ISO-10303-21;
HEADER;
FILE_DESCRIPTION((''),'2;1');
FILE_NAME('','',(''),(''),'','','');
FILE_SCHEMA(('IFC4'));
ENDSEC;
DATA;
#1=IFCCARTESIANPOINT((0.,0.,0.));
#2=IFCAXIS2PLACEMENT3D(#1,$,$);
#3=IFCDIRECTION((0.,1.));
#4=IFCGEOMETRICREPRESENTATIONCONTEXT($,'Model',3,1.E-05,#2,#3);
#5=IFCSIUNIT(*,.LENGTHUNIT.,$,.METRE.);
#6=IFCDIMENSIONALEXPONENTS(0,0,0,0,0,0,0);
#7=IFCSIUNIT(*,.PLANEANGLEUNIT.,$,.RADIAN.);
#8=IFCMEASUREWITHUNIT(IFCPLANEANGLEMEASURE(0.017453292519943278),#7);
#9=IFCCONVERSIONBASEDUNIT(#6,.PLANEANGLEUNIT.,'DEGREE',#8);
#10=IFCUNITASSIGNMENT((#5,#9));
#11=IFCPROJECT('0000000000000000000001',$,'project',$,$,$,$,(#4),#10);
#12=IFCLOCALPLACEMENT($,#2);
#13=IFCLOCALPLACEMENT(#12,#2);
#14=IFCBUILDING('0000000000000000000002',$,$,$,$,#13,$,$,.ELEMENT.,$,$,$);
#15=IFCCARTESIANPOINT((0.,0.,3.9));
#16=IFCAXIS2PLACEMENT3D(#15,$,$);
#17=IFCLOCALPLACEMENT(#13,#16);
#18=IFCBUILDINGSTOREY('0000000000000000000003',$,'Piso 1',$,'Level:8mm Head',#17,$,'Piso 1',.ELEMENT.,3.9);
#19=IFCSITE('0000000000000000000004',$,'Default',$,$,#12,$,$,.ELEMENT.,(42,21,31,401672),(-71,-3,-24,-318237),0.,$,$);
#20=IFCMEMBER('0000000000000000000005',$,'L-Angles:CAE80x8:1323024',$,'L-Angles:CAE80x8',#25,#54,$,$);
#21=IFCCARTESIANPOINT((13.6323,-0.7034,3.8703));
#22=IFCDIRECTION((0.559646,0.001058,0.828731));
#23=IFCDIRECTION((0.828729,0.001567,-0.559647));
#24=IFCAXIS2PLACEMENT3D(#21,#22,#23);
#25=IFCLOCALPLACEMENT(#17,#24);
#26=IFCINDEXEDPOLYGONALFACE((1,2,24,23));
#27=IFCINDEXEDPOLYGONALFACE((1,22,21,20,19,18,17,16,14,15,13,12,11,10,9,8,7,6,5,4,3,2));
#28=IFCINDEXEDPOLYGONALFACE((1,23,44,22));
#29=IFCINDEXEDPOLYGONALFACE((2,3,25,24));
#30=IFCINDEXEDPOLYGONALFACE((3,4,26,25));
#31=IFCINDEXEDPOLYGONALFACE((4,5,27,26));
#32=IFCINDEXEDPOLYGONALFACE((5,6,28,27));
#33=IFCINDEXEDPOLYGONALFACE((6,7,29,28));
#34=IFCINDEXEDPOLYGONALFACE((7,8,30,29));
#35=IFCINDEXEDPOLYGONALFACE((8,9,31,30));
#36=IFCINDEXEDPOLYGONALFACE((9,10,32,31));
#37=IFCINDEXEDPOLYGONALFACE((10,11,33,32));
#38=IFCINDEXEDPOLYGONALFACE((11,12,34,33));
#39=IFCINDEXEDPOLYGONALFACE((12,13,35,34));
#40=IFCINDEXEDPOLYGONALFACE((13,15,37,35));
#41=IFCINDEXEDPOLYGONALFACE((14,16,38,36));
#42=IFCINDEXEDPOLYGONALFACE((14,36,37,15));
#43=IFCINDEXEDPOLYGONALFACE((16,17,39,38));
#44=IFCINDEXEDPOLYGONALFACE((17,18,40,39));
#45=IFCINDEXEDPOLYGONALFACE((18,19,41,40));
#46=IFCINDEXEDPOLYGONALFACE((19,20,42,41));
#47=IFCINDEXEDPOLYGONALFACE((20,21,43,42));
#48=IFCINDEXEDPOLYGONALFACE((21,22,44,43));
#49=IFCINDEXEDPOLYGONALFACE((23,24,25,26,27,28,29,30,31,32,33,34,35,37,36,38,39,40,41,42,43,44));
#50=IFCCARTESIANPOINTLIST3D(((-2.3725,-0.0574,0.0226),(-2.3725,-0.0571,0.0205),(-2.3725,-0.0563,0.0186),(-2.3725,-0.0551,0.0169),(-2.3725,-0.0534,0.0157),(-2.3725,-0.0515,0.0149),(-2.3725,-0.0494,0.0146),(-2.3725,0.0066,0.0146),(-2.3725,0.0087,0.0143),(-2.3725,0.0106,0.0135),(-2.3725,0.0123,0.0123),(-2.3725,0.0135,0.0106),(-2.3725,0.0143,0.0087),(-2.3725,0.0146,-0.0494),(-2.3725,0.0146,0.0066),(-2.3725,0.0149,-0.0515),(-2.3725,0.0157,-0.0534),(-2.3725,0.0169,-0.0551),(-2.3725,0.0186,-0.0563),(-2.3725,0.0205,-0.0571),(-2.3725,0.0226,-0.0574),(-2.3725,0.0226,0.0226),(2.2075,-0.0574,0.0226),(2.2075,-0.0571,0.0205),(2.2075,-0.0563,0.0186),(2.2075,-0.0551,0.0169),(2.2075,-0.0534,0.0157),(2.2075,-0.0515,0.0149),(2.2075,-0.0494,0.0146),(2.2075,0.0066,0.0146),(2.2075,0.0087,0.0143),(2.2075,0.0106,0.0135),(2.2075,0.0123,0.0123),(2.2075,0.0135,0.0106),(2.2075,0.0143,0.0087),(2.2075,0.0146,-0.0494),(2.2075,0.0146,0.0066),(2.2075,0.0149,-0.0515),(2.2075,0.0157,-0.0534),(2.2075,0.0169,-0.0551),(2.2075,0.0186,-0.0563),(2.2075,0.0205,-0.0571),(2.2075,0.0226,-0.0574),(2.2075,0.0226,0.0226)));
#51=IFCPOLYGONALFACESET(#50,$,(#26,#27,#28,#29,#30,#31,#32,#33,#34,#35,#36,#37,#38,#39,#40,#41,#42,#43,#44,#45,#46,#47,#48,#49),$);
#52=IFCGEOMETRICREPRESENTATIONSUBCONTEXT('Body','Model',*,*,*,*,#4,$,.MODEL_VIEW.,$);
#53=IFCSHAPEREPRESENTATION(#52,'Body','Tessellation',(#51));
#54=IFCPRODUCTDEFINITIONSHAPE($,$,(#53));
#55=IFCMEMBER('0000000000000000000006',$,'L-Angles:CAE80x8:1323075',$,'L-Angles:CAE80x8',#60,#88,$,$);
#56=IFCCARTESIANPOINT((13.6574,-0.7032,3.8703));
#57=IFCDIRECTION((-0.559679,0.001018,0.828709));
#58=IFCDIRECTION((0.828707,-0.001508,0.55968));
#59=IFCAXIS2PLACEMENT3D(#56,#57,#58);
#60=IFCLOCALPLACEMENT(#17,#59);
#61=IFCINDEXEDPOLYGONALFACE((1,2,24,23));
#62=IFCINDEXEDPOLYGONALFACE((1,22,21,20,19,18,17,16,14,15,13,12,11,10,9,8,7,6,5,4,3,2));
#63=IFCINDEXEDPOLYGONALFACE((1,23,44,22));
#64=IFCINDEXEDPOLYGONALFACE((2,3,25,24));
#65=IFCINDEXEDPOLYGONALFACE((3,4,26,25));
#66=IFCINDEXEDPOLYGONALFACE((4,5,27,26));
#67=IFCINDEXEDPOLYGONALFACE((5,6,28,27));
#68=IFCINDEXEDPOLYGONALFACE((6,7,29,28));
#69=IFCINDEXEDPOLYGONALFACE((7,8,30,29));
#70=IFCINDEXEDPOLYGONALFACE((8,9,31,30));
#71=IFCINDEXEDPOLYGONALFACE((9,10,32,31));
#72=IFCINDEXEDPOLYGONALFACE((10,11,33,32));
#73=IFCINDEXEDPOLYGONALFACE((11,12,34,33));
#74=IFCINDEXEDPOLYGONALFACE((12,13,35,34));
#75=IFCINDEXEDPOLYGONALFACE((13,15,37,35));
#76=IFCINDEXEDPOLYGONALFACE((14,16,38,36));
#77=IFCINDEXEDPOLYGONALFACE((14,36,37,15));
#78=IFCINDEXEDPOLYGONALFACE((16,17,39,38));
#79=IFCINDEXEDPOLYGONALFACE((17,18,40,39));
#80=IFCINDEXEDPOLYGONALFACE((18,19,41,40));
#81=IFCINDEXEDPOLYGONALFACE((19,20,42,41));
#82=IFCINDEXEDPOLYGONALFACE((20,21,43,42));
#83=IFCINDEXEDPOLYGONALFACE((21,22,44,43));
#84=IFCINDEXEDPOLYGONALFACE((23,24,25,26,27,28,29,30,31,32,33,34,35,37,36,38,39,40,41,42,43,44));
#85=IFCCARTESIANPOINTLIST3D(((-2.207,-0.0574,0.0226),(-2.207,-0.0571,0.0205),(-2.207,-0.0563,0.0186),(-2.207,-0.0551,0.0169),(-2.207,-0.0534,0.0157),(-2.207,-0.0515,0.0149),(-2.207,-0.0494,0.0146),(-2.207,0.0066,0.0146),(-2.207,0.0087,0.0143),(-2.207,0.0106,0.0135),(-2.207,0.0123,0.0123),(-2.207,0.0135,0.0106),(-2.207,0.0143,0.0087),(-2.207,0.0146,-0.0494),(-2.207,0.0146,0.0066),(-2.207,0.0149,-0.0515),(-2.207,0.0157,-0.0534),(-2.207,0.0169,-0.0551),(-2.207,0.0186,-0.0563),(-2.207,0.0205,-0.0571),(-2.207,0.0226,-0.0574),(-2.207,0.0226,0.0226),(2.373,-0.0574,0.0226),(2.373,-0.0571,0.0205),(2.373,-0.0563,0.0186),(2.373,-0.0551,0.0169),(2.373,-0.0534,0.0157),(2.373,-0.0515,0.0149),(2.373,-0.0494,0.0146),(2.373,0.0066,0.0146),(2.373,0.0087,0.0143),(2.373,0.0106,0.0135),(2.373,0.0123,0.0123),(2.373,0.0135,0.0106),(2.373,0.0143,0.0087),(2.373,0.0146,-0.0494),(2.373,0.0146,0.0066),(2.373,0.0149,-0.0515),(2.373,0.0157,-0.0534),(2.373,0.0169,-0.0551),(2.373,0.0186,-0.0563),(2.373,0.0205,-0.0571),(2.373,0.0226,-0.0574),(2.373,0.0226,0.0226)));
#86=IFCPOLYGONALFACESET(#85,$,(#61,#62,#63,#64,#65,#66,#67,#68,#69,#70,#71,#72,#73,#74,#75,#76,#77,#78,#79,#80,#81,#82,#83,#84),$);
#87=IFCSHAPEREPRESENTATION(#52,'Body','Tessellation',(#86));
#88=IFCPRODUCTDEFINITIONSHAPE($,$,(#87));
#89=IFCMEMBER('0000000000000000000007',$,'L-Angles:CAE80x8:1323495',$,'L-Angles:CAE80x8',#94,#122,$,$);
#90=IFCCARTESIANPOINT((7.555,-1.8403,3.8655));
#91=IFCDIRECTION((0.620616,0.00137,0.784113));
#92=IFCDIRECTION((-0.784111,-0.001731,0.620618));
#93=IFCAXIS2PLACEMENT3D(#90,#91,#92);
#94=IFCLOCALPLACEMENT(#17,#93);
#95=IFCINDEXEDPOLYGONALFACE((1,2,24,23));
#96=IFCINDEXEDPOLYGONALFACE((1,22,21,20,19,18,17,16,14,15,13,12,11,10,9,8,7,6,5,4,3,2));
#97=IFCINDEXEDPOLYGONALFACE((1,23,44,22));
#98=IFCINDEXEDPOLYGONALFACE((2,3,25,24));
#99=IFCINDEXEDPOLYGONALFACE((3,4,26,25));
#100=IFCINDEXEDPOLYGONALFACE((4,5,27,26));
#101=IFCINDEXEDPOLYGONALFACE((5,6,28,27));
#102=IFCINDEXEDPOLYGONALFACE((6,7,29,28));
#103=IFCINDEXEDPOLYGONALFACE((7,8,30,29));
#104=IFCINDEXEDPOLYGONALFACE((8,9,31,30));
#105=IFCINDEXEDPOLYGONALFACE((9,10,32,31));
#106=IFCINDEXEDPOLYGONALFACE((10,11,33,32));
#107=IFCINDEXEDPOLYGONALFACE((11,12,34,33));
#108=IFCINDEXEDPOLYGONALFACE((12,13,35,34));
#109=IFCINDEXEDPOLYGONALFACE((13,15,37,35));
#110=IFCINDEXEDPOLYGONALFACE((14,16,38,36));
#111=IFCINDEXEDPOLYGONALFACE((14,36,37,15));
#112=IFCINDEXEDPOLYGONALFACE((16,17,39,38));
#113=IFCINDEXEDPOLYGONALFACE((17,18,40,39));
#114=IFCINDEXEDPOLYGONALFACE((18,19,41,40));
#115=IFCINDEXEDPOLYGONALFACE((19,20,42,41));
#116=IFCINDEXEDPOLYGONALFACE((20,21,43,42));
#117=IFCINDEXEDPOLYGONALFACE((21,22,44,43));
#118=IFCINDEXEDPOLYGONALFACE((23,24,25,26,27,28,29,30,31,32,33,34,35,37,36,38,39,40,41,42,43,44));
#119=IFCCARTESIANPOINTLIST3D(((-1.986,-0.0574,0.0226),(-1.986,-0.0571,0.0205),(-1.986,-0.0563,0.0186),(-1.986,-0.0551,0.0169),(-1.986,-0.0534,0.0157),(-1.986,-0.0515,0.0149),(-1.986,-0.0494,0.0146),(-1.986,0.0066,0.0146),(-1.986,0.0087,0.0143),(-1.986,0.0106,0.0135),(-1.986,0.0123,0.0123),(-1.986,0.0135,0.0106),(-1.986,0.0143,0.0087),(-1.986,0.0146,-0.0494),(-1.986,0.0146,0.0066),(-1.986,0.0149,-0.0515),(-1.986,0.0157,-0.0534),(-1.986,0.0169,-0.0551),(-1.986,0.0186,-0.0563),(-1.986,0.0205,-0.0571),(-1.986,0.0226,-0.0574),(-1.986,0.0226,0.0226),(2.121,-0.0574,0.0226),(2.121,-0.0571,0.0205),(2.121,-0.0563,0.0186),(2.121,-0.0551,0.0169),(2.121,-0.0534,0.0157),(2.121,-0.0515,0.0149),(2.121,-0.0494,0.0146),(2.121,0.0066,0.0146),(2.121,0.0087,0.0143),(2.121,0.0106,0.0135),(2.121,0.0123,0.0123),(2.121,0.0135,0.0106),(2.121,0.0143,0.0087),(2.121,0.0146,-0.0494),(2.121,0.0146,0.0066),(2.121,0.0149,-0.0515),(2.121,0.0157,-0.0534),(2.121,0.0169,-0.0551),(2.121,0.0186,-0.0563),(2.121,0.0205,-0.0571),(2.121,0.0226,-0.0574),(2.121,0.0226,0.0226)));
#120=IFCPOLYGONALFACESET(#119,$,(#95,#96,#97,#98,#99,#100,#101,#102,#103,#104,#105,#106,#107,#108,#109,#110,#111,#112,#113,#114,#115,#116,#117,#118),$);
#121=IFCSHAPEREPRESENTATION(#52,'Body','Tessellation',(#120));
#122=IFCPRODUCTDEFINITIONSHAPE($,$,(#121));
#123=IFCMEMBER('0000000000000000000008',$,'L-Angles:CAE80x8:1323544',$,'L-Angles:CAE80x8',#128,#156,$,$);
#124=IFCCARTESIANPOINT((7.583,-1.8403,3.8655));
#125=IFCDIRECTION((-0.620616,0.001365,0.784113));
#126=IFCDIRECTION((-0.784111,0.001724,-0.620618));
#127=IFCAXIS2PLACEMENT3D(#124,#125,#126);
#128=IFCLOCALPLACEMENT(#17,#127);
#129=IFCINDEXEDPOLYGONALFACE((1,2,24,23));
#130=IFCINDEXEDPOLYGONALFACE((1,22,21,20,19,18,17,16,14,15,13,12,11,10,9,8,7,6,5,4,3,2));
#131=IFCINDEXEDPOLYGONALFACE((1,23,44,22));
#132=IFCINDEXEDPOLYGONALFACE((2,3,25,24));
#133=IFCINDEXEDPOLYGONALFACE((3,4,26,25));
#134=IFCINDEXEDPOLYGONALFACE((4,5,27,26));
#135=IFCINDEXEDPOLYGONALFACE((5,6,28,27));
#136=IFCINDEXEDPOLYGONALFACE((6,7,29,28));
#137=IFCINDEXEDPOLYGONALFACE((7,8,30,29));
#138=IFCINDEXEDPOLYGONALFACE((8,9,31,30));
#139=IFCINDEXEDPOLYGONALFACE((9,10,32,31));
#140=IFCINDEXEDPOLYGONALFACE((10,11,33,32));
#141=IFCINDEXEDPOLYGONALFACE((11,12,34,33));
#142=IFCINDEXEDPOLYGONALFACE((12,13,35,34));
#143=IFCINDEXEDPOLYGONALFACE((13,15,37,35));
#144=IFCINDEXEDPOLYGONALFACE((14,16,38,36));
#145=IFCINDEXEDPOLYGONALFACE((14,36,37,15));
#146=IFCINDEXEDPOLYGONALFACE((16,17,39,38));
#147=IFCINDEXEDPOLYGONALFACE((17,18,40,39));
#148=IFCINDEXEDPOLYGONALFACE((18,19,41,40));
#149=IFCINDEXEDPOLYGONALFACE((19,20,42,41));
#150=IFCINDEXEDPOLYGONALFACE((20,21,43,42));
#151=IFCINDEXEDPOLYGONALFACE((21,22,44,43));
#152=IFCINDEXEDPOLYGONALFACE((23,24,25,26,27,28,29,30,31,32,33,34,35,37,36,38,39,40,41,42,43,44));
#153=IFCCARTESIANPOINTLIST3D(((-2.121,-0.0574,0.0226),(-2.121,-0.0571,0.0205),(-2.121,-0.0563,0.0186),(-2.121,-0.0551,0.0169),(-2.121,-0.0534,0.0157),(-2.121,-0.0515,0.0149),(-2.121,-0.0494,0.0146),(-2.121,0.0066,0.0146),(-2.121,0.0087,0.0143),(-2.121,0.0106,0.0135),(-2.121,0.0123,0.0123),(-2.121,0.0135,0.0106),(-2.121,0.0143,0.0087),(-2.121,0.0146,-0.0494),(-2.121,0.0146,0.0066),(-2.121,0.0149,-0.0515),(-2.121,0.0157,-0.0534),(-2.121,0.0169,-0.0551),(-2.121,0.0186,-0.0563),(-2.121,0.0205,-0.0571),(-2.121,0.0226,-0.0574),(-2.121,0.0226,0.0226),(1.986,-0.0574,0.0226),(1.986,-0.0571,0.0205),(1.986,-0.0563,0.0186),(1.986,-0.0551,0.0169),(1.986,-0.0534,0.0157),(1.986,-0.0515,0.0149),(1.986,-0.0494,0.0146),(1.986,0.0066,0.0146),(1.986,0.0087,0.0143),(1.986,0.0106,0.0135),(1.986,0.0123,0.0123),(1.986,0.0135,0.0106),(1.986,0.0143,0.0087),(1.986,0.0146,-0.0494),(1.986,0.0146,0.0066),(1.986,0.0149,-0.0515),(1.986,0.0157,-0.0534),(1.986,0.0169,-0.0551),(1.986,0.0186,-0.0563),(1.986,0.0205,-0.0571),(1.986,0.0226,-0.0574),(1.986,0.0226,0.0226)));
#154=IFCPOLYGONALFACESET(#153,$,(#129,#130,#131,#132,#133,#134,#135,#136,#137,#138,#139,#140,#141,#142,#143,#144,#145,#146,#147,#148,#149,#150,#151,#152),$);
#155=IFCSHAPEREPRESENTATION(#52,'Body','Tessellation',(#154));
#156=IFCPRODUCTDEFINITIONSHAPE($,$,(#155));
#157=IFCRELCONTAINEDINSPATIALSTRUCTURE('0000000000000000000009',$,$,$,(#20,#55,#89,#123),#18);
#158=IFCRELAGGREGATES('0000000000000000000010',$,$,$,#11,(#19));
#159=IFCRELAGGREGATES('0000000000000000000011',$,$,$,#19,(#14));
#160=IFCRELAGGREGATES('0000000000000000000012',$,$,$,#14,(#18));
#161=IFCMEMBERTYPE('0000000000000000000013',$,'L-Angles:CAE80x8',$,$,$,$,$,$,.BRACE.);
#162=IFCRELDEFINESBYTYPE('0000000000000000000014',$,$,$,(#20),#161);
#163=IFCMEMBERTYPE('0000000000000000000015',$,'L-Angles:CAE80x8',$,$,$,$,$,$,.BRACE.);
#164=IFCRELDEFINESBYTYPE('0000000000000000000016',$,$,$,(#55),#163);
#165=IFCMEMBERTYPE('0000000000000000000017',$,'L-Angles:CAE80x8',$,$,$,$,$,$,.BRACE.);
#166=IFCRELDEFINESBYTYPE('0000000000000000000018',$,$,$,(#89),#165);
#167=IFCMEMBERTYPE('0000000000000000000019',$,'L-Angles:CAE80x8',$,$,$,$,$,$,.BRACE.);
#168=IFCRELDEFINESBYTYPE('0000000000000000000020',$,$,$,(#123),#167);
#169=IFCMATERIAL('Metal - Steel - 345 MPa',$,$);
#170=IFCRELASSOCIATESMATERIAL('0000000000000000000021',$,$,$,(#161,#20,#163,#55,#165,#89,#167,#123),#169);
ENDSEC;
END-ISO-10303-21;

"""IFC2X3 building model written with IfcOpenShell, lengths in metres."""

from ifc_helpers import new_model, entity, si_unit, converted_unit, direction, frame, frame_2d, origin, place, context, subcontext, project, spatial, polyline, circle_curve, parameter, trimmed, segment, composite_curve, outline, extrude, source, transform, mapped, material, type_object, type_shapes, element, save


model = new_model("IFC2X3")

# Units and contexts
model_context = context("Model", 3, precision=1e-05, world=origin(), true_north=direction((0.0, 1.0)))
body_context = subcontext(model_context, "Body", "Model", "MODEL_VIEW")
ifc_project = project(units=[si_unit("LENGTHUNIT", "METRE"), converted_unit("PLANEANGLEUNIT", "DEGREE", entity("IfcPlaneAngleMeasure", 0.017453292519943278), si_unit("PLANEANGLEUNIT", "RADIAN"), dimensions=[0, 0, 0, 0, 0, 0, 0])], contexts=[model_context])

# Site, building, storey
site_placement = place(None, origin())
site = spatial("IfcSite", under=ifc_project, at=site_placement, Name="Default", CompositionType="ELEMENT", RefLatitude=(42, 21, 31, 401672), RefLongitude=(-71, -3, -24, -318237), RefElevation=0.0)
building_placement = place(site_placement, origin())
building = spatial("IfcBuilding", under=site, at=building_placement, CompositionType="ELEMENT")
storey_placement = place(building_placement, frame((0.0, 0.0, 3.9)))
storey = spatial("IfcBuildingStorey", under=building, at=storey_placement, Name="Piso 1", ObjectType="Level:8mm Head", LongName="Piso 1", CompositionType="ELEMENT", Elevation=3.9)

# Shared definitions
ifc_material = material(Name="Metal - Steel - 345 MPa")

# Members
member_type_1 = type_object("IfcMemberType", Name="L-Angles:CAE80x8", PredefinedType="BRACE", material=ifc_material)
shared_shape_1 = source(origin(), body_context, "Body", "SweptSolid", [
    extrude(outline(composite_curve([segment(polyline([(-0.0263, -0.0263), (0.0537, -0.0263)]), True, "CONTINUOUS"), segment(trimmed(circle_curve(frame_2d((0.0457, -0.0263), x_axis=(1.0, 0.0)), 0.008), [parameter(0.0)], [parameter(90.0)], True, "PARAMETER"), True, "CONTINUOUS"), segment(polyline([(0.0457, -0.0183), (-0.0103, -0.0183)]), True, "CONTINUOUS"), segment(trimmed(circle_curve(frame_2d((-0.0103, -0.0103), x_axis=(1.0, 0.0)), 0.008), [parameter(180.0)], [parameter(270.0)], True, "PARAMETER"), False, "CONTINUOUS"), segment(polyline([(-0.0183, -0.0103), (-0.0183, 0.0457)]), True, "CONTINUOUS"), segment(trimmed(circle_curve(frame_2d((-0.0263, 0.0457), x_axis=(1.0, 0.0)), 0.008), [parameter(0.0)], [parameter(90.0)], True, "PARAMETER"), True, "CONTINUOUS"), segment(polyline([(-0.0263, 0.0537), (-0.0263, -0.0263)]), True, "CONTINUOUS")], self_intersect=False)), frame((-2.3725, -0.0037, -0.0037), z_axis=(1.0, 0.0, 0.0), x_axis=(0.0, -1.0, 0.0)), (0.0, 0.0, 1.0), 4.58),
])
type_shapes(member_type_1, [shared_shape_1])
member_1_placement = place(storey_placement, frame((13.6323, -0.7034, 3.8703), z_axis=(0.559646, 0.001058, 0.828731), x_axis=(0.828729, 0.001567, -0.559647)))
element("IfcMember", 1, at=member_1_placement, inside=storey, type_object=member_type_1, material=ifc_material, Name="L-Angles:CAE80x8:1323024", ObjectType="L-Angles:CAE80x8", context=body_context, shape_type="MappedRepresentation", body=[
    mapped(shared_shape_1, transform((0.0, 0.0, 0.0), scale=1.0)),
])
member_type_2 = type_object("IfcMemberType", Name="L-Angles:CAE80x8", PredefinedType="BRACE", material=ifc_material)
shared_shape_2 = source(origin(), body_context, "Body", "SweptSolid", [
    extrude(outline(composite_curve([segment(polyline([(-0.0263, -0.0263), (0.0537, -0.0263)]), True, "CONTINUOUS"), segment(trimmed(circle_curve(frame_2d((0.0457, -0.0263), x_axis=(1.0, 0.0)), 0.008), [parameter(0.0)], [parameter(90.0)], True, "PARAMETER"), True, "CONTINUOUS"), segment(polyline([(0.0457, -0.0183), (-0.0103, -0.0183)]), True, "CONTINUOUS"), segment(trimmed(circle_curve(frame_2d((-0.0103, -0.0103), x_axis=(1.0, 0.0)), 0.008), [parameter(180.0)], [parameter(270.0)], True, "PARAMETER"), False, "CONTINUOUS"), segment(polyline([(-0.0183, -0.0103), (-0.0183, 0.0457)]), True, "CONTINUOUS"), segment(trimmed(circle_curve(frame_2d((-0.0263, 0.0457), x_axis=(1.0, 0.0)), 0.008), [parameter(0.0)], [parameter(90.0)], True, "PARAMETER"), True, "CONTINUOUS"), segment(polyline([(-0.0263, 0.0537), (-0.0263, -0.0263)]), True, "CONTINUOUS")], self_intersect=False)), frame((-2.207, -0.0037, -0.0037), z_axis=(1.0, 0.0, 0.0), x_axis=(0.0, -1.0, 0.0)), (0.0, 0.0, 1.0), 4.58),
])
type_shapes(member_type_2, [shared_shape_2])
member_2_placement = place(storey_placement, frame((13.6574, -0.7032, 3.8703), z_axis=(-0.559679, 0.001018, 0.828709), x_axis=(0.828707, -0.001508, 0.55968)))
element("IfcMember", 2, at=member_2_placement, inside=storey, type_object=member_type_2, material=ifc_material, Name="L-Angles:CAE80x8:1323075", ObjectType="L-Angles:CAE80x8", context=body_context, shape_type="MappedRepresentation", body=[
    mapped(shared_shape_2, transform((0.0, 0.0, 0.0), scale=1.0)),
])
member_type_3 = type_object("IfcMemberType", Name="L-Angles:CAE80x8", PredefinedType="BRACE", material=ifc_material)
shared_shape_3 = source(origin(), body_context, "Body", "SweptSolid", [
    extrude(outline(composite_curve([segment(polyline([(-0.0263, -0.0263), (0.0537, -0.0263)]), True, "CONTINUOUS"), segment(trimmed(circle_curve(frame_2d((0.0457, -0.0263), x_axis=(1.0, 0.0)), 0.008), [parameter(0.0)], [parameter(90.0)], True, "PARAMETER"), True, "CONTINUOUS"), segment(polyline([(0.0457, -0.0183), (-0.0103, -0.0183)]), True, "CONTINUOUS"), segment(trimmed(circle_curve(frame_2d((-0.0103, -0.0103), x_axis=(1.0, 0.0)), 0.008), [parameter(180.0)], [parameter(270.0)], True, "PARAMETER"), False, "CONTINUOUS"), segment(polyline([(-0.0183, -0.0103), (-0.0183, 0.0457)]), True, "CONTINUOUS"), segment(trimmed(circle_curve(frame_2d((-0.0263, 0.0457), x_axis=(1.0, 0.0)), 0.008), [parameter(0.0)], [parameter(90.0)], True, "PARAMETER"), True, "CONTINUOUS"), segment(polyline([(-0.0263, 0.0537), (-0.0263, -0.0263)]), True, "CONTINUOUS")], self_intersect=False)), frame((-1.986, -0.0037, -0.0037), z_axis=(1.0, 0.0, 0.0), x_axis=(0.0, -1.0, 0.0)), (0.0, 0.0, 1.0), 4.107),
])
type_shapes(member_type_3, [shared_shape_3])
member_3_placement = place(storey_placement, frame((7.555, -1.8403, 3.8655), z_axis=(0.620616, 0.00137, 0.784113), x_axis=(-0.784111, -0.001731, 0.620618)))
element("IfcMember", 3, at=member_3_placement, inside=storey, type_object=member_type_3, material=ifc_material, Name="L-Angles:CAE80x8:1323495", ObjectType="L-Angles:CAE80x8", context=body_context, shape_type="MappedRepresentation", body=[
    mapped(shared_shape_3, transform((0.0, 0.0, 0.0), scale=1.0)),
])
member_type_4 = type_object("IfcMemberType", Name="L-Angles:CAE80x8", PredefinedType="BRACE", material=ifc_material)
shared_shape_4 = source(origin(), body_context, "Body", "SweptSolid", [
    extrude(outline(composite_curve([segment(polyline([(-0.0263, -0.0263), (0.0537, -0.0263)]), True, "CONTINUOUS"), segment(trimmed(circle_curve(frame_2d((0.0457, -0.0263), x_axis=(1.0, 0.0)), 0.008), [parameter(0.0)], [parameter(90.0)], True, "PARAMETER"), True, "CONTINUOUS"), segment(polyline([(0.0457, -0.0183), (-0.0103, -0.0183)]), True, "CONTINUOUS"), segment(trimmed(circle_curve(frame_2d((-0.0103, -0.0103), x_axis=(1.0, 0.0)), 0.008), [parameter(180.0)], [parameter(270.0)], True, "PARAMETER"), False, "CONTINUOUS"), segment(polyline([(-0.0183, -0.0103), (-0.0183, 0.0457)]), True, "CONTINUOUS"), segment(trimmed(circle_curve(frame_2d((-0.0263, 0.0457), x_axis=(1.0, 0.0)), 0.008), [parameter(0.0)], [parameter(90.0)], True, "PARAMETER"), True, "CONTINUOUS"), segment(polyline([(-0.0263, 0.0537), (-0.0263, -0.0263)]), True, "CONTINUOUS")], self_intersect=False)), frame((-2.121, -0.0037, -0.0037), z_axis=(1.0, 0.0, 0.0), x_axis=(0.0, -1.0, 0.0)), (0.0, 0.0, 1.0), 4.107),
])
type_shapes(member_type_4, [shared_shape_4])
member_4_placement = place(storey_placement, frame((7.583, -1.8403, 3.8655), z_axis=(-0.620616, 0.001365, 0.784113), x_axis=(-0.784111, 0.001724, -0.620618)))
element("IfcMember", 4, at=member_4_placement, inside=storey, type_object=member_type_4, material=ifc_material, Name="L-Angles:CAE80x8:1323544", ObjectType="L-Angles:CAE80x8", context=body_context, shape_type="MappedRepresentation", body=[
    mapped(shared_shape_4, transform((0.0, 0.0, 0.0), scale=1.0)),
])

save(model, "model.ifc")
